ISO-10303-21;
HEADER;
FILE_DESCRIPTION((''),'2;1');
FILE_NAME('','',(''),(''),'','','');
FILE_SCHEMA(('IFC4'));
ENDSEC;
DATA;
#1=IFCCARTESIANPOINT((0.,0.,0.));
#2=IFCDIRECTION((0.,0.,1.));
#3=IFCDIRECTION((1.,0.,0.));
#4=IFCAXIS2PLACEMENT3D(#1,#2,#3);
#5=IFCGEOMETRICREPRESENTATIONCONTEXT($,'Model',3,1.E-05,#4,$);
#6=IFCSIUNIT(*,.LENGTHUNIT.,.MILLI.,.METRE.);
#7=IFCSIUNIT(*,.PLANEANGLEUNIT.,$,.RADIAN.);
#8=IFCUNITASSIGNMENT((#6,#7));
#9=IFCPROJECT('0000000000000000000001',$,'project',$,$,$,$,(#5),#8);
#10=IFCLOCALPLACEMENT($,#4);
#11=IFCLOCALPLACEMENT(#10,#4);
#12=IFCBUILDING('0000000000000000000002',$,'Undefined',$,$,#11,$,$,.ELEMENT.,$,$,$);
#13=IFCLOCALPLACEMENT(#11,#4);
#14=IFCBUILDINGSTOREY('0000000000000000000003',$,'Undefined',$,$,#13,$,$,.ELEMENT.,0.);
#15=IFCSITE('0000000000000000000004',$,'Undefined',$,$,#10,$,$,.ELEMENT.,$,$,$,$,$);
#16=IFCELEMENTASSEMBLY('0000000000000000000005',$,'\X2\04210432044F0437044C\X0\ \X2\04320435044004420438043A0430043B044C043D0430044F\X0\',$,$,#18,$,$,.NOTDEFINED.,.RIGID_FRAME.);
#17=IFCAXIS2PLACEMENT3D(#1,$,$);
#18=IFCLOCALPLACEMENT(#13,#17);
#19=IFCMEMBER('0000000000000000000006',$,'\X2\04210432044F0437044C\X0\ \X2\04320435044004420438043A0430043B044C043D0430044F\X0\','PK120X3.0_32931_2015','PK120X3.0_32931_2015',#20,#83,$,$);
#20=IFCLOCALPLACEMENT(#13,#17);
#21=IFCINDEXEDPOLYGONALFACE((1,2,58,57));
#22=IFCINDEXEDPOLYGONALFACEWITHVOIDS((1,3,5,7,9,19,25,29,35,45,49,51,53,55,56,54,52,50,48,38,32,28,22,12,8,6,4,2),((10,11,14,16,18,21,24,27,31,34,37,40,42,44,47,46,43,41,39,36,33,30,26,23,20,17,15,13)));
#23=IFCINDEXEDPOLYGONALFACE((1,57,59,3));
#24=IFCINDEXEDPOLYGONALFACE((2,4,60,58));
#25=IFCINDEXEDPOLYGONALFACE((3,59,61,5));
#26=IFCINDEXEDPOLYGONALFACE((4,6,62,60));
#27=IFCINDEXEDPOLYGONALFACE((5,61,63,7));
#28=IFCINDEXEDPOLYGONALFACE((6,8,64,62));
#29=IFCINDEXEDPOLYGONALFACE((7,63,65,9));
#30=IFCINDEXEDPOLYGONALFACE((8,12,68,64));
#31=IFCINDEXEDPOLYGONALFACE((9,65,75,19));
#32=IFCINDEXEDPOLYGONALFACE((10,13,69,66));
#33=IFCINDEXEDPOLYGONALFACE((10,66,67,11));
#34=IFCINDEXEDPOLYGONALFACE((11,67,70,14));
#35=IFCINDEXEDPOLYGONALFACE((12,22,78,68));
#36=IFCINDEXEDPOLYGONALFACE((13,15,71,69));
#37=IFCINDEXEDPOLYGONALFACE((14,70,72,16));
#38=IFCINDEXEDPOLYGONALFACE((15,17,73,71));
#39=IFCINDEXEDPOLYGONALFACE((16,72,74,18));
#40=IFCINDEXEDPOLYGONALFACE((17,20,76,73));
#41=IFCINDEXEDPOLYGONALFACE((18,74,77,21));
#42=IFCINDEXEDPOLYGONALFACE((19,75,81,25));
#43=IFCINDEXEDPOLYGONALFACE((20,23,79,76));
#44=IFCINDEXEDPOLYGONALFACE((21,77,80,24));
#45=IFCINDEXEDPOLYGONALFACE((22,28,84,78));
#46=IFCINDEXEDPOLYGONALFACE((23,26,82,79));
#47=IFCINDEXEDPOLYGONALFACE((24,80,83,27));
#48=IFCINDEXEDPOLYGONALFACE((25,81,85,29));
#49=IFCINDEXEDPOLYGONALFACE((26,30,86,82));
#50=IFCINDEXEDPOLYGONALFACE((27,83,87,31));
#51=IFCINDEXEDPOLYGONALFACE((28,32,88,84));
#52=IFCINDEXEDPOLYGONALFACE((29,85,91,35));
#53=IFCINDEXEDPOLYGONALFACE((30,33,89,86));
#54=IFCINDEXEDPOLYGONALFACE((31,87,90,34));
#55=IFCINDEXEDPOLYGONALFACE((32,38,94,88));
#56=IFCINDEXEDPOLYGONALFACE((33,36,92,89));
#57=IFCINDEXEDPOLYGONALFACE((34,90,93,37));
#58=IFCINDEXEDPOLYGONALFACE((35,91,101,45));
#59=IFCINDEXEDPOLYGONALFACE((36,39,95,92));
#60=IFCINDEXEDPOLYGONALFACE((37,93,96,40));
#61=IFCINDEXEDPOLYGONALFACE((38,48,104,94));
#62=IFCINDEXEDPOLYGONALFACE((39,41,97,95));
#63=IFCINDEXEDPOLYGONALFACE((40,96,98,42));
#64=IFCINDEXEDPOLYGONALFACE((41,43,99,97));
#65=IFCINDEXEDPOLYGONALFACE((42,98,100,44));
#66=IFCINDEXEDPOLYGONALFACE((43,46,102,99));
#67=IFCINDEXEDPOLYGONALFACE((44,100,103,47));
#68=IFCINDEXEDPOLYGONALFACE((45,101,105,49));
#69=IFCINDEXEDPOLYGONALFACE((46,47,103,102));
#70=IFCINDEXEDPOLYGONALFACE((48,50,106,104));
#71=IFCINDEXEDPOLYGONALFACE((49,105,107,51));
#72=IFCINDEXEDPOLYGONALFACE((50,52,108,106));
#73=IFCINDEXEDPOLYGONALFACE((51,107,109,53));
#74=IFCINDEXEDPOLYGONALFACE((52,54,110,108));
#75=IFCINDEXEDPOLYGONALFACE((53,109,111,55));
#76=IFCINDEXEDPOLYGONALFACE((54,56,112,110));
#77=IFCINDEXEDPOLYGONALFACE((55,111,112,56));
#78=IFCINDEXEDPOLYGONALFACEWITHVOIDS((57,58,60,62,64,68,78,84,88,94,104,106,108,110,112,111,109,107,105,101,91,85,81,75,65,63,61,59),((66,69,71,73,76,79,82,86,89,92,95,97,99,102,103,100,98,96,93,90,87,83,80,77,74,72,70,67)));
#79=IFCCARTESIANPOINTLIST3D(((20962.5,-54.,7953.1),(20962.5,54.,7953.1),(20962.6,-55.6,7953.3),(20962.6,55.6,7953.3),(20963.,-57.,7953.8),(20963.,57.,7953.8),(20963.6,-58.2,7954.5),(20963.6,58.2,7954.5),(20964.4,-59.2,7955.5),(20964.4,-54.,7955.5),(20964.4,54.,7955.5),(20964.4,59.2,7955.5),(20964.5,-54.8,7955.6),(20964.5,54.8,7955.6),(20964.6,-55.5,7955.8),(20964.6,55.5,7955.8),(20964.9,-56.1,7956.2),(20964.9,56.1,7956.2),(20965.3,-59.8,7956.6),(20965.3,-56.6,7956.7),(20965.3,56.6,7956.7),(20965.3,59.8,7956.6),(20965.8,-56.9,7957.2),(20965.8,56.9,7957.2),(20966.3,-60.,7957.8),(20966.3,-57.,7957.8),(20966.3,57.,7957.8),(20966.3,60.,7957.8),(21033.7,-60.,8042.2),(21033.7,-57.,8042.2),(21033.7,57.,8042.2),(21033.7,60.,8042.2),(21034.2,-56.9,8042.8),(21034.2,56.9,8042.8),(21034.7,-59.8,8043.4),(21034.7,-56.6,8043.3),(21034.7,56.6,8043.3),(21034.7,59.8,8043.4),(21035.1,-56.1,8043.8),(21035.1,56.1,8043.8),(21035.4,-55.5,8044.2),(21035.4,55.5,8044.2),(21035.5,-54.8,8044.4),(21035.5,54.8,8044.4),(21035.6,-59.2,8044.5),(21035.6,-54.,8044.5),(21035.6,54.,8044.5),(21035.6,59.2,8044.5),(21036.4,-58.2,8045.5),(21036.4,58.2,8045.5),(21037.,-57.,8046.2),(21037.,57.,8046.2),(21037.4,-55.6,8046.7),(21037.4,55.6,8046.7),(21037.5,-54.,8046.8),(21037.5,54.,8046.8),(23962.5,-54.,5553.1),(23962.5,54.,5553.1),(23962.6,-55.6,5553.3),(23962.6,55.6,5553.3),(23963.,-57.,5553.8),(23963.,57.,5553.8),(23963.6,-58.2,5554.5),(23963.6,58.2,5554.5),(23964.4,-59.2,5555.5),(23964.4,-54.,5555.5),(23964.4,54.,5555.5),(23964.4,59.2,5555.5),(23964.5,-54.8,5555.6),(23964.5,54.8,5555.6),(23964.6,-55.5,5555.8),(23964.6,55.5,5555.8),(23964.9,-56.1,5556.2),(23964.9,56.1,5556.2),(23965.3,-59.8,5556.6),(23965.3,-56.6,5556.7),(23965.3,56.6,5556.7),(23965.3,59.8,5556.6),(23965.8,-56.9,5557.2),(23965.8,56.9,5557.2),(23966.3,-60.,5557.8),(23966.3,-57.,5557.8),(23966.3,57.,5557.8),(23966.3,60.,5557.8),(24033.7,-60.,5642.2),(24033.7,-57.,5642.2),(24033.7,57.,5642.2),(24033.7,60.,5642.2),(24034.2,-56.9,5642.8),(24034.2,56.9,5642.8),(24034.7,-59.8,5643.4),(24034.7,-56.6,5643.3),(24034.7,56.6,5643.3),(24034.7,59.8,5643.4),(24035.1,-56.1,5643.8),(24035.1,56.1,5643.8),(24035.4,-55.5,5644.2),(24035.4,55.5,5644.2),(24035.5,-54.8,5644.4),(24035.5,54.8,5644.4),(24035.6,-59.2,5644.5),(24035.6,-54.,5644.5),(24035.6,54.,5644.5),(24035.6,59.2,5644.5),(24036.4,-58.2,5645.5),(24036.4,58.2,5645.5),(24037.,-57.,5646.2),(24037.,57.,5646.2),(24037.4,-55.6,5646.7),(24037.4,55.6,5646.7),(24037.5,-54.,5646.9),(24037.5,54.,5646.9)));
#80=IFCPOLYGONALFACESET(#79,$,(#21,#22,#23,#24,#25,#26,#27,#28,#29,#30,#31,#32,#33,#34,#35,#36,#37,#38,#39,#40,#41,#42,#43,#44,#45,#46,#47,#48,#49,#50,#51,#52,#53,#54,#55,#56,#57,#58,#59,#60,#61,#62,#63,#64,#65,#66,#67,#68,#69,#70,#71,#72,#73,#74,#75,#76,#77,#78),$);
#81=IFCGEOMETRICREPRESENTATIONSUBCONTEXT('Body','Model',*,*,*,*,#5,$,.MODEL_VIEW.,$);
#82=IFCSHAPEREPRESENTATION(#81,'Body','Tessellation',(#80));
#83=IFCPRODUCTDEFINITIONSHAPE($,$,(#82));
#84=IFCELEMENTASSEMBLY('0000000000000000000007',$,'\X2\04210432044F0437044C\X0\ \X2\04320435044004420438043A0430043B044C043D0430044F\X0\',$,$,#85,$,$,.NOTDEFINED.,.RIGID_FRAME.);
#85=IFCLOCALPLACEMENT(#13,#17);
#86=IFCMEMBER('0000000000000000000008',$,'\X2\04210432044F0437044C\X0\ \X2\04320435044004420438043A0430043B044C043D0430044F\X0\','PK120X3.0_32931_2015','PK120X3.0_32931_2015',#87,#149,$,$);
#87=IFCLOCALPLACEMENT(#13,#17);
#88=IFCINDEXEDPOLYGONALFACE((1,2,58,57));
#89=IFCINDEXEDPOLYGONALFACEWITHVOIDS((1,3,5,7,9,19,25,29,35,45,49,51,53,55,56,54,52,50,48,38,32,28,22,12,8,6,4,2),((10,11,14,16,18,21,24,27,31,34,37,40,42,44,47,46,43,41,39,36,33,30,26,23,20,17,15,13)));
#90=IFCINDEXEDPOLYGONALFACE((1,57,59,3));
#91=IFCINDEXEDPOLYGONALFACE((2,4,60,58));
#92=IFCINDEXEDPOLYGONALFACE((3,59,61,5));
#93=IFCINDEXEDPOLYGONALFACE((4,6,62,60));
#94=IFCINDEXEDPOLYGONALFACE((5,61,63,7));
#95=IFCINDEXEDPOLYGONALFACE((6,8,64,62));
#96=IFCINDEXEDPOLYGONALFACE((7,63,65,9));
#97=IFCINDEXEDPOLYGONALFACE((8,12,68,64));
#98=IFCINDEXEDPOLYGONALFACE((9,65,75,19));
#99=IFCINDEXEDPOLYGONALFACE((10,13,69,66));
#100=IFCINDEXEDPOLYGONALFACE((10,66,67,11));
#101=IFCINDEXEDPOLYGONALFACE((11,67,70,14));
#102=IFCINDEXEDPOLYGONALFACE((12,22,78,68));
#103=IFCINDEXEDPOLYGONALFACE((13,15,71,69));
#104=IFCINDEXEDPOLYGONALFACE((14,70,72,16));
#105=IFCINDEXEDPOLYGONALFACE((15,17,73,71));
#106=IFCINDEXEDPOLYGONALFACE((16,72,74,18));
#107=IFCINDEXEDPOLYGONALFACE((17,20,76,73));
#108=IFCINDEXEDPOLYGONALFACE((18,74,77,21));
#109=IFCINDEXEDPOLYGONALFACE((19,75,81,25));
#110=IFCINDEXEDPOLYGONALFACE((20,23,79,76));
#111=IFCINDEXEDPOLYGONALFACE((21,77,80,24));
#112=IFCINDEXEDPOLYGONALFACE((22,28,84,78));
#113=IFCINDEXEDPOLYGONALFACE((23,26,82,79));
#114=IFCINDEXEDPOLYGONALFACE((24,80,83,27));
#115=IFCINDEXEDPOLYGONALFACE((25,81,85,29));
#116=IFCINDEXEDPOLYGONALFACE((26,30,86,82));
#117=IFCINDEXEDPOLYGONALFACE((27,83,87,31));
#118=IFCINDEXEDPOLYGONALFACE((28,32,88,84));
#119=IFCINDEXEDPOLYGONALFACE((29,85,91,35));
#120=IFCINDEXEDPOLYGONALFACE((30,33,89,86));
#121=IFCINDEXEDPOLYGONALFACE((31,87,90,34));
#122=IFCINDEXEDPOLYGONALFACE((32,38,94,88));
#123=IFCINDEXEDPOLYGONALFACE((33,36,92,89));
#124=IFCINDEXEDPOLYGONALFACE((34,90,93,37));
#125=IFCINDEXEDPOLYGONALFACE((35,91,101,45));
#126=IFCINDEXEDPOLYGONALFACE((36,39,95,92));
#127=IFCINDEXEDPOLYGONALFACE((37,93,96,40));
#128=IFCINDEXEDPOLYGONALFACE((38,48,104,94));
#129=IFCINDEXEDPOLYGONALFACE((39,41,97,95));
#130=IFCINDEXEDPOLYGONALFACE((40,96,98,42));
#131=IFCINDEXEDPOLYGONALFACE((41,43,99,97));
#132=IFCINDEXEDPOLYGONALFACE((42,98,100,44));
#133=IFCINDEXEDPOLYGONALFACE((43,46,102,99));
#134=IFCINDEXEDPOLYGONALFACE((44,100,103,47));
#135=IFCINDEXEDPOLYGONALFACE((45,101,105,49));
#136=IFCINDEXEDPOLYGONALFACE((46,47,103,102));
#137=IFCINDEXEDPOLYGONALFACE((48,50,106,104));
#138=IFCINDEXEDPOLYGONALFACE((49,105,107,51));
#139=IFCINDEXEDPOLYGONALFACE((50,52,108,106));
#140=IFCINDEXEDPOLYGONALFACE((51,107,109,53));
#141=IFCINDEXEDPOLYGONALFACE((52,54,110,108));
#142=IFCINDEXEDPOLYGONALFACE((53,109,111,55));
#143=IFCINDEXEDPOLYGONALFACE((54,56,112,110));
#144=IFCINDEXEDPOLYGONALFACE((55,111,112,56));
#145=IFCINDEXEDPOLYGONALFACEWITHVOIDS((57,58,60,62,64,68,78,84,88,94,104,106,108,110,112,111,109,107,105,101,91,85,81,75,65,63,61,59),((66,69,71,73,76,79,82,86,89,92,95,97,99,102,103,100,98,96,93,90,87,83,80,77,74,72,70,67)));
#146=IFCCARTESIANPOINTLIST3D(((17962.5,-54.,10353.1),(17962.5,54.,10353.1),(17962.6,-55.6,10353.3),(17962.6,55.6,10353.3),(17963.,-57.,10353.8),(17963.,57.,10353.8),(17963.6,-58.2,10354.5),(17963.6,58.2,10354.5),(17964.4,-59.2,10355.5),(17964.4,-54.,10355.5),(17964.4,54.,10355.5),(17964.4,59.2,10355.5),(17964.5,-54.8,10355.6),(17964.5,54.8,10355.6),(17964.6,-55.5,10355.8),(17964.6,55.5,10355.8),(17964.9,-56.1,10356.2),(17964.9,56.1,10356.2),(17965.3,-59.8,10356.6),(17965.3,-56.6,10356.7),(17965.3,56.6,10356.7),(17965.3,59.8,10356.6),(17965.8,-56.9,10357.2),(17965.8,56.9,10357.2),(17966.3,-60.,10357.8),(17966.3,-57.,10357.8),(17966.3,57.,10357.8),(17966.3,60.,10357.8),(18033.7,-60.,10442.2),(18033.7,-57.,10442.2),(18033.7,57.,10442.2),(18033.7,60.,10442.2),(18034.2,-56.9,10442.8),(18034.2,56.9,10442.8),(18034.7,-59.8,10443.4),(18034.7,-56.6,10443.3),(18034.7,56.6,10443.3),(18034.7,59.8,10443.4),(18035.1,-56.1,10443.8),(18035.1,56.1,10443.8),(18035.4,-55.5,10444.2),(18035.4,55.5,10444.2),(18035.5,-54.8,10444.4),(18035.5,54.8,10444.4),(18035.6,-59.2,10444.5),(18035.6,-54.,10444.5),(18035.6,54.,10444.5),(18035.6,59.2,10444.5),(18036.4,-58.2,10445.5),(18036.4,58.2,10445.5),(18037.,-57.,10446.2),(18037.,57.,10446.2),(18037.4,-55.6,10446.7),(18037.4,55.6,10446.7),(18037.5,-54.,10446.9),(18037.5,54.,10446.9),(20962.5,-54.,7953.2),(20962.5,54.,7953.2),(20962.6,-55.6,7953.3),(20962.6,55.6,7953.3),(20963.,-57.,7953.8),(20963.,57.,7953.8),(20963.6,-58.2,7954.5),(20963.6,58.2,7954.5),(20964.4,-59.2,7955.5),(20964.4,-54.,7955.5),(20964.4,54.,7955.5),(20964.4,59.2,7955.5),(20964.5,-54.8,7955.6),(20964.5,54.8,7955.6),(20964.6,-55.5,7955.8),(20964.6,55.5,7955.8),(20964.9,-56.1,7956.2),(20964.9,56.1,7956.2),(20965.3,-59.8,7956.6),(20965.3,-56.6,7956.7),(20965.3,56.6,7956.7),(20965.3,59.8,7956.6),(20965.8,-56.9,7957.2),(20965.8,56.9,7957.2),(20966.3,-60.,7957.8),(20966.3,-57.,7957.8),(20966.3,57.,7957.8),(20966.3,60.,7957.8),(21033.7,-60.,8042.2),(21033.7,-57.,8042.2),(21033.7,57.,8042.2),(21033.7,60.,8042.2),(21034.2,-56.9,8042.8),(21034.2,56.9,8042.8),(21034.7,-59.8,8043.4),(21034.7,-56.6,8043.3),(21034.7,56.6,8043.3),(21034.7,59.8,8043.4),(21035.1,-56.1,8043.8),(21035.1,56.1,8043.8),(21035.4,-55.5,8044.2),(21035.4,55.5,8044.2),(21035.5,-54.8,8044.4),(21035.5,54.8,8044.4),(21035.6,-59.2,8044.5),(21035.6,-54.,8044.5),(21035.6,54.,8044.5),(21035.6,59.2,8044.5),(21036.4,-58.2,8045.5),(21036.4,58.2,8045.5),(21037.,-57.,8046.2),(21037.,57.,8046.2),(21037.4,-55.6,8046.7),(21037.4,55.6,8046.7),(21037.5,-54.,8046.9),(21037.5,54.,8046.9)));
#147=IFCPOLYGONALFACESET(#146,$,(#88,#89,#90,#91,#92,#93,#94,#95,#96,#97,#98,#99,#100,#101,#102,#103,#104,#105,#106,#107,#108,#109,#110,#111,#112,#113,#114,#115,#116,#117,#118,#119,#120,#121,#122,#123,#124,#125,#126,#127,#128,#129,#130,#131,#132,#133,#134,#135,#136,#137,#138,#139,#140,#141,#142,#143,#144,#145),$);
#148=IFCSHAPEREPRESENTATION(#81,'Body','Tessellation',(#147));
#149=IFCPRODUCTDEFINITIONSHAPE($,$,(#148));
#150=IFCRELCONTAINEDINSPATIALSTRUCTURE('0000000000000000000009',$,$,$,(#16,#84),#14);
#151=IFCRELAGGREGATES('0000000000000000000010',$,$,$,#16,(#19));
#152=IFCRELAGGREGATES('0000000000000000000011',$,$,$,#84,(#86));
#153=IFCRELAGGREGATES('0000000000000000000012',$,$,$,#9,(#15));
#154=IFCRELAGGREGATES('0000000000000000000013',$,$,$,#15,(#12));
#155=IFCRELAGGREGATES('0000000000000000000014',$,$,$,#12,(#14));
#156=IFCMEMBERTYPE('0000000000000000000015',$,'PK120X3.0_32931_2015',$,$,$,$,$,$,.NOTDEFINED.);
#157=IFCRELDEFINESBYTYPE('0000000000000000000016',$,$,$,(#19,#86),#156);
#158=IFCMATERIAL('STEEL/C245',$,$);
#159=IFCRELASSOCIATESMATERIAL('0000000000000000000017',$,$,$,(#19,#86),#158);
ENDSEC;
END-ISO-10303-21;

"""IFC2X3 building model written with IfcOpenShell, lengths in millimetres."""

from ifc_helpers import new_model, si_unit, frame, origin_with_axes, origin_2d_with_axis, place, context, subcontext, project, spatial, hollow_rectangle, extrude, material, type_object, element, aggregate, save


model = new_model("IFC2X3")

# Units and contexts
model_context = context("Model", 3, precision=1e-05, world=origin_with_axes())
body_context = subcontext(model_context, "Body", "Model", "MODEL_VIEW")
ifc_project = project(units=[si_unit("LENGTHUNIT", "METRE", prefix="MILLI"), si_unit("PLANEANGLEUNIT", "RADIAN")], contexts=[model_context])

# Site, building, storey
site_placement = place(None, origin_with_axes())
site = spatial("IfcSite", under=ifc_project, at=site_placement, Name="Undefined", CompositionType="ELEMENT")
building_placement = place(site_placement, origin_with_axes())
building = spatial("IfcBuilding", under=site, at=building_placement, Name="Undefined", CompositionType="ELEMENT")
storey_placement = place(building_placement, origin_with_axes())
storey = spatial("IfcBuildingStorey", under=building, at=storey_placement, Name="Undefined", CompositionType="ELEMENT", Elevation=0.0)

# Shared definitions
ifc_material_1 = material(Name="STEEL/C245")

# Element assemblies, members
member_type_1 = type_object("IfcMemberType", Name="PK120X3.0_32931_2015", PredefinedType="NOTDEFINED")
assembly_1_placement = place(storey_placement, origin_with_axes())
assembly_1 = element("IfcElementAssembly", 1, at=assembly_1_placement, inside=storey, Name="Связь вертикальная", AssemblyPlace="NOTDEFINED", PredefinedType="RIGID_FRAME")
member_1_placement = place(assembly_1_placement, frame((21000.0, 0.0, 8000.0), z_axis=(-0.624695, 0.0, -0.780869), x_axis=(0.780869, 0.0, -0.624695)))
member_1 = element("IfcMember", 2, at=member_1_placement, type_object=member_type_1, material=ifc_material_1, Name="Связь вертикальная", Description="PK120X3.0_32931_2015", ObjectType="PK120X3.0_32931_2015", context=body_context, shape_type="SweptSolid", body=[
    extrude(hollow_rectangle(XDim=120.0, YDim=120.0, WallThickness=3.0, InnerFilletRadius=3.0, OuterFilletRadius=6.0, at=origin_2d_with_axis()), frame((3841.9, 0.0, 0.0), z_axis=(-1.0, 0.0, 0.0), x_axis=(0.0, -1.0, 0.0)), (0.0, 0.0, 1.0), 3841.9),
])
aggregate(assembly_1, [member_1])
assembly_2_placement = place(storey_placement, origin_with_axes())
assembly_2 = element("IfcElementAssembly", 3, at=assembly_2_placement, inside=storey, Name="Связь вертикальная", AssemblyPlace="NOTDEFINED", PredefinedType="RIGID_FRAME")
member_2_placement = place(assembly_2_placement, frame((21000.0, 0.0, 8000.0), z_axis=(0.624695, 0.0, 0.780869), x_axis=(-0.780869, 0.0, 0.624695)))
member_2 = element("IfcMember", 4, at=member_2_placement, type_object=member_type_1, material=ifc_material_1, Name="Связь вертикальная", Description="PK120X3.0_32931_2015", ObjectType="PK120X3.0_32931_2015", context=body_context, shape_type="SweptSolid", body=[
    extrude(hollow_rectangle(XDim=120.0, YDim=120.0, WallThickness=3.0, InnerFilletRadius=3.0, OuterFilletRadius=6.0, at=origin_2d_with_axis()), frame((3841.9, 0.0, 0.0), z_axis=(-1.0, 0.0, 0.0), x_axis=(0.0, -1.0, 0.0)), (0.0, 0.0, 1.0), 3841.9),
])
aggregate(assembly_2, [member_2])

save(model, "model.ifc")
